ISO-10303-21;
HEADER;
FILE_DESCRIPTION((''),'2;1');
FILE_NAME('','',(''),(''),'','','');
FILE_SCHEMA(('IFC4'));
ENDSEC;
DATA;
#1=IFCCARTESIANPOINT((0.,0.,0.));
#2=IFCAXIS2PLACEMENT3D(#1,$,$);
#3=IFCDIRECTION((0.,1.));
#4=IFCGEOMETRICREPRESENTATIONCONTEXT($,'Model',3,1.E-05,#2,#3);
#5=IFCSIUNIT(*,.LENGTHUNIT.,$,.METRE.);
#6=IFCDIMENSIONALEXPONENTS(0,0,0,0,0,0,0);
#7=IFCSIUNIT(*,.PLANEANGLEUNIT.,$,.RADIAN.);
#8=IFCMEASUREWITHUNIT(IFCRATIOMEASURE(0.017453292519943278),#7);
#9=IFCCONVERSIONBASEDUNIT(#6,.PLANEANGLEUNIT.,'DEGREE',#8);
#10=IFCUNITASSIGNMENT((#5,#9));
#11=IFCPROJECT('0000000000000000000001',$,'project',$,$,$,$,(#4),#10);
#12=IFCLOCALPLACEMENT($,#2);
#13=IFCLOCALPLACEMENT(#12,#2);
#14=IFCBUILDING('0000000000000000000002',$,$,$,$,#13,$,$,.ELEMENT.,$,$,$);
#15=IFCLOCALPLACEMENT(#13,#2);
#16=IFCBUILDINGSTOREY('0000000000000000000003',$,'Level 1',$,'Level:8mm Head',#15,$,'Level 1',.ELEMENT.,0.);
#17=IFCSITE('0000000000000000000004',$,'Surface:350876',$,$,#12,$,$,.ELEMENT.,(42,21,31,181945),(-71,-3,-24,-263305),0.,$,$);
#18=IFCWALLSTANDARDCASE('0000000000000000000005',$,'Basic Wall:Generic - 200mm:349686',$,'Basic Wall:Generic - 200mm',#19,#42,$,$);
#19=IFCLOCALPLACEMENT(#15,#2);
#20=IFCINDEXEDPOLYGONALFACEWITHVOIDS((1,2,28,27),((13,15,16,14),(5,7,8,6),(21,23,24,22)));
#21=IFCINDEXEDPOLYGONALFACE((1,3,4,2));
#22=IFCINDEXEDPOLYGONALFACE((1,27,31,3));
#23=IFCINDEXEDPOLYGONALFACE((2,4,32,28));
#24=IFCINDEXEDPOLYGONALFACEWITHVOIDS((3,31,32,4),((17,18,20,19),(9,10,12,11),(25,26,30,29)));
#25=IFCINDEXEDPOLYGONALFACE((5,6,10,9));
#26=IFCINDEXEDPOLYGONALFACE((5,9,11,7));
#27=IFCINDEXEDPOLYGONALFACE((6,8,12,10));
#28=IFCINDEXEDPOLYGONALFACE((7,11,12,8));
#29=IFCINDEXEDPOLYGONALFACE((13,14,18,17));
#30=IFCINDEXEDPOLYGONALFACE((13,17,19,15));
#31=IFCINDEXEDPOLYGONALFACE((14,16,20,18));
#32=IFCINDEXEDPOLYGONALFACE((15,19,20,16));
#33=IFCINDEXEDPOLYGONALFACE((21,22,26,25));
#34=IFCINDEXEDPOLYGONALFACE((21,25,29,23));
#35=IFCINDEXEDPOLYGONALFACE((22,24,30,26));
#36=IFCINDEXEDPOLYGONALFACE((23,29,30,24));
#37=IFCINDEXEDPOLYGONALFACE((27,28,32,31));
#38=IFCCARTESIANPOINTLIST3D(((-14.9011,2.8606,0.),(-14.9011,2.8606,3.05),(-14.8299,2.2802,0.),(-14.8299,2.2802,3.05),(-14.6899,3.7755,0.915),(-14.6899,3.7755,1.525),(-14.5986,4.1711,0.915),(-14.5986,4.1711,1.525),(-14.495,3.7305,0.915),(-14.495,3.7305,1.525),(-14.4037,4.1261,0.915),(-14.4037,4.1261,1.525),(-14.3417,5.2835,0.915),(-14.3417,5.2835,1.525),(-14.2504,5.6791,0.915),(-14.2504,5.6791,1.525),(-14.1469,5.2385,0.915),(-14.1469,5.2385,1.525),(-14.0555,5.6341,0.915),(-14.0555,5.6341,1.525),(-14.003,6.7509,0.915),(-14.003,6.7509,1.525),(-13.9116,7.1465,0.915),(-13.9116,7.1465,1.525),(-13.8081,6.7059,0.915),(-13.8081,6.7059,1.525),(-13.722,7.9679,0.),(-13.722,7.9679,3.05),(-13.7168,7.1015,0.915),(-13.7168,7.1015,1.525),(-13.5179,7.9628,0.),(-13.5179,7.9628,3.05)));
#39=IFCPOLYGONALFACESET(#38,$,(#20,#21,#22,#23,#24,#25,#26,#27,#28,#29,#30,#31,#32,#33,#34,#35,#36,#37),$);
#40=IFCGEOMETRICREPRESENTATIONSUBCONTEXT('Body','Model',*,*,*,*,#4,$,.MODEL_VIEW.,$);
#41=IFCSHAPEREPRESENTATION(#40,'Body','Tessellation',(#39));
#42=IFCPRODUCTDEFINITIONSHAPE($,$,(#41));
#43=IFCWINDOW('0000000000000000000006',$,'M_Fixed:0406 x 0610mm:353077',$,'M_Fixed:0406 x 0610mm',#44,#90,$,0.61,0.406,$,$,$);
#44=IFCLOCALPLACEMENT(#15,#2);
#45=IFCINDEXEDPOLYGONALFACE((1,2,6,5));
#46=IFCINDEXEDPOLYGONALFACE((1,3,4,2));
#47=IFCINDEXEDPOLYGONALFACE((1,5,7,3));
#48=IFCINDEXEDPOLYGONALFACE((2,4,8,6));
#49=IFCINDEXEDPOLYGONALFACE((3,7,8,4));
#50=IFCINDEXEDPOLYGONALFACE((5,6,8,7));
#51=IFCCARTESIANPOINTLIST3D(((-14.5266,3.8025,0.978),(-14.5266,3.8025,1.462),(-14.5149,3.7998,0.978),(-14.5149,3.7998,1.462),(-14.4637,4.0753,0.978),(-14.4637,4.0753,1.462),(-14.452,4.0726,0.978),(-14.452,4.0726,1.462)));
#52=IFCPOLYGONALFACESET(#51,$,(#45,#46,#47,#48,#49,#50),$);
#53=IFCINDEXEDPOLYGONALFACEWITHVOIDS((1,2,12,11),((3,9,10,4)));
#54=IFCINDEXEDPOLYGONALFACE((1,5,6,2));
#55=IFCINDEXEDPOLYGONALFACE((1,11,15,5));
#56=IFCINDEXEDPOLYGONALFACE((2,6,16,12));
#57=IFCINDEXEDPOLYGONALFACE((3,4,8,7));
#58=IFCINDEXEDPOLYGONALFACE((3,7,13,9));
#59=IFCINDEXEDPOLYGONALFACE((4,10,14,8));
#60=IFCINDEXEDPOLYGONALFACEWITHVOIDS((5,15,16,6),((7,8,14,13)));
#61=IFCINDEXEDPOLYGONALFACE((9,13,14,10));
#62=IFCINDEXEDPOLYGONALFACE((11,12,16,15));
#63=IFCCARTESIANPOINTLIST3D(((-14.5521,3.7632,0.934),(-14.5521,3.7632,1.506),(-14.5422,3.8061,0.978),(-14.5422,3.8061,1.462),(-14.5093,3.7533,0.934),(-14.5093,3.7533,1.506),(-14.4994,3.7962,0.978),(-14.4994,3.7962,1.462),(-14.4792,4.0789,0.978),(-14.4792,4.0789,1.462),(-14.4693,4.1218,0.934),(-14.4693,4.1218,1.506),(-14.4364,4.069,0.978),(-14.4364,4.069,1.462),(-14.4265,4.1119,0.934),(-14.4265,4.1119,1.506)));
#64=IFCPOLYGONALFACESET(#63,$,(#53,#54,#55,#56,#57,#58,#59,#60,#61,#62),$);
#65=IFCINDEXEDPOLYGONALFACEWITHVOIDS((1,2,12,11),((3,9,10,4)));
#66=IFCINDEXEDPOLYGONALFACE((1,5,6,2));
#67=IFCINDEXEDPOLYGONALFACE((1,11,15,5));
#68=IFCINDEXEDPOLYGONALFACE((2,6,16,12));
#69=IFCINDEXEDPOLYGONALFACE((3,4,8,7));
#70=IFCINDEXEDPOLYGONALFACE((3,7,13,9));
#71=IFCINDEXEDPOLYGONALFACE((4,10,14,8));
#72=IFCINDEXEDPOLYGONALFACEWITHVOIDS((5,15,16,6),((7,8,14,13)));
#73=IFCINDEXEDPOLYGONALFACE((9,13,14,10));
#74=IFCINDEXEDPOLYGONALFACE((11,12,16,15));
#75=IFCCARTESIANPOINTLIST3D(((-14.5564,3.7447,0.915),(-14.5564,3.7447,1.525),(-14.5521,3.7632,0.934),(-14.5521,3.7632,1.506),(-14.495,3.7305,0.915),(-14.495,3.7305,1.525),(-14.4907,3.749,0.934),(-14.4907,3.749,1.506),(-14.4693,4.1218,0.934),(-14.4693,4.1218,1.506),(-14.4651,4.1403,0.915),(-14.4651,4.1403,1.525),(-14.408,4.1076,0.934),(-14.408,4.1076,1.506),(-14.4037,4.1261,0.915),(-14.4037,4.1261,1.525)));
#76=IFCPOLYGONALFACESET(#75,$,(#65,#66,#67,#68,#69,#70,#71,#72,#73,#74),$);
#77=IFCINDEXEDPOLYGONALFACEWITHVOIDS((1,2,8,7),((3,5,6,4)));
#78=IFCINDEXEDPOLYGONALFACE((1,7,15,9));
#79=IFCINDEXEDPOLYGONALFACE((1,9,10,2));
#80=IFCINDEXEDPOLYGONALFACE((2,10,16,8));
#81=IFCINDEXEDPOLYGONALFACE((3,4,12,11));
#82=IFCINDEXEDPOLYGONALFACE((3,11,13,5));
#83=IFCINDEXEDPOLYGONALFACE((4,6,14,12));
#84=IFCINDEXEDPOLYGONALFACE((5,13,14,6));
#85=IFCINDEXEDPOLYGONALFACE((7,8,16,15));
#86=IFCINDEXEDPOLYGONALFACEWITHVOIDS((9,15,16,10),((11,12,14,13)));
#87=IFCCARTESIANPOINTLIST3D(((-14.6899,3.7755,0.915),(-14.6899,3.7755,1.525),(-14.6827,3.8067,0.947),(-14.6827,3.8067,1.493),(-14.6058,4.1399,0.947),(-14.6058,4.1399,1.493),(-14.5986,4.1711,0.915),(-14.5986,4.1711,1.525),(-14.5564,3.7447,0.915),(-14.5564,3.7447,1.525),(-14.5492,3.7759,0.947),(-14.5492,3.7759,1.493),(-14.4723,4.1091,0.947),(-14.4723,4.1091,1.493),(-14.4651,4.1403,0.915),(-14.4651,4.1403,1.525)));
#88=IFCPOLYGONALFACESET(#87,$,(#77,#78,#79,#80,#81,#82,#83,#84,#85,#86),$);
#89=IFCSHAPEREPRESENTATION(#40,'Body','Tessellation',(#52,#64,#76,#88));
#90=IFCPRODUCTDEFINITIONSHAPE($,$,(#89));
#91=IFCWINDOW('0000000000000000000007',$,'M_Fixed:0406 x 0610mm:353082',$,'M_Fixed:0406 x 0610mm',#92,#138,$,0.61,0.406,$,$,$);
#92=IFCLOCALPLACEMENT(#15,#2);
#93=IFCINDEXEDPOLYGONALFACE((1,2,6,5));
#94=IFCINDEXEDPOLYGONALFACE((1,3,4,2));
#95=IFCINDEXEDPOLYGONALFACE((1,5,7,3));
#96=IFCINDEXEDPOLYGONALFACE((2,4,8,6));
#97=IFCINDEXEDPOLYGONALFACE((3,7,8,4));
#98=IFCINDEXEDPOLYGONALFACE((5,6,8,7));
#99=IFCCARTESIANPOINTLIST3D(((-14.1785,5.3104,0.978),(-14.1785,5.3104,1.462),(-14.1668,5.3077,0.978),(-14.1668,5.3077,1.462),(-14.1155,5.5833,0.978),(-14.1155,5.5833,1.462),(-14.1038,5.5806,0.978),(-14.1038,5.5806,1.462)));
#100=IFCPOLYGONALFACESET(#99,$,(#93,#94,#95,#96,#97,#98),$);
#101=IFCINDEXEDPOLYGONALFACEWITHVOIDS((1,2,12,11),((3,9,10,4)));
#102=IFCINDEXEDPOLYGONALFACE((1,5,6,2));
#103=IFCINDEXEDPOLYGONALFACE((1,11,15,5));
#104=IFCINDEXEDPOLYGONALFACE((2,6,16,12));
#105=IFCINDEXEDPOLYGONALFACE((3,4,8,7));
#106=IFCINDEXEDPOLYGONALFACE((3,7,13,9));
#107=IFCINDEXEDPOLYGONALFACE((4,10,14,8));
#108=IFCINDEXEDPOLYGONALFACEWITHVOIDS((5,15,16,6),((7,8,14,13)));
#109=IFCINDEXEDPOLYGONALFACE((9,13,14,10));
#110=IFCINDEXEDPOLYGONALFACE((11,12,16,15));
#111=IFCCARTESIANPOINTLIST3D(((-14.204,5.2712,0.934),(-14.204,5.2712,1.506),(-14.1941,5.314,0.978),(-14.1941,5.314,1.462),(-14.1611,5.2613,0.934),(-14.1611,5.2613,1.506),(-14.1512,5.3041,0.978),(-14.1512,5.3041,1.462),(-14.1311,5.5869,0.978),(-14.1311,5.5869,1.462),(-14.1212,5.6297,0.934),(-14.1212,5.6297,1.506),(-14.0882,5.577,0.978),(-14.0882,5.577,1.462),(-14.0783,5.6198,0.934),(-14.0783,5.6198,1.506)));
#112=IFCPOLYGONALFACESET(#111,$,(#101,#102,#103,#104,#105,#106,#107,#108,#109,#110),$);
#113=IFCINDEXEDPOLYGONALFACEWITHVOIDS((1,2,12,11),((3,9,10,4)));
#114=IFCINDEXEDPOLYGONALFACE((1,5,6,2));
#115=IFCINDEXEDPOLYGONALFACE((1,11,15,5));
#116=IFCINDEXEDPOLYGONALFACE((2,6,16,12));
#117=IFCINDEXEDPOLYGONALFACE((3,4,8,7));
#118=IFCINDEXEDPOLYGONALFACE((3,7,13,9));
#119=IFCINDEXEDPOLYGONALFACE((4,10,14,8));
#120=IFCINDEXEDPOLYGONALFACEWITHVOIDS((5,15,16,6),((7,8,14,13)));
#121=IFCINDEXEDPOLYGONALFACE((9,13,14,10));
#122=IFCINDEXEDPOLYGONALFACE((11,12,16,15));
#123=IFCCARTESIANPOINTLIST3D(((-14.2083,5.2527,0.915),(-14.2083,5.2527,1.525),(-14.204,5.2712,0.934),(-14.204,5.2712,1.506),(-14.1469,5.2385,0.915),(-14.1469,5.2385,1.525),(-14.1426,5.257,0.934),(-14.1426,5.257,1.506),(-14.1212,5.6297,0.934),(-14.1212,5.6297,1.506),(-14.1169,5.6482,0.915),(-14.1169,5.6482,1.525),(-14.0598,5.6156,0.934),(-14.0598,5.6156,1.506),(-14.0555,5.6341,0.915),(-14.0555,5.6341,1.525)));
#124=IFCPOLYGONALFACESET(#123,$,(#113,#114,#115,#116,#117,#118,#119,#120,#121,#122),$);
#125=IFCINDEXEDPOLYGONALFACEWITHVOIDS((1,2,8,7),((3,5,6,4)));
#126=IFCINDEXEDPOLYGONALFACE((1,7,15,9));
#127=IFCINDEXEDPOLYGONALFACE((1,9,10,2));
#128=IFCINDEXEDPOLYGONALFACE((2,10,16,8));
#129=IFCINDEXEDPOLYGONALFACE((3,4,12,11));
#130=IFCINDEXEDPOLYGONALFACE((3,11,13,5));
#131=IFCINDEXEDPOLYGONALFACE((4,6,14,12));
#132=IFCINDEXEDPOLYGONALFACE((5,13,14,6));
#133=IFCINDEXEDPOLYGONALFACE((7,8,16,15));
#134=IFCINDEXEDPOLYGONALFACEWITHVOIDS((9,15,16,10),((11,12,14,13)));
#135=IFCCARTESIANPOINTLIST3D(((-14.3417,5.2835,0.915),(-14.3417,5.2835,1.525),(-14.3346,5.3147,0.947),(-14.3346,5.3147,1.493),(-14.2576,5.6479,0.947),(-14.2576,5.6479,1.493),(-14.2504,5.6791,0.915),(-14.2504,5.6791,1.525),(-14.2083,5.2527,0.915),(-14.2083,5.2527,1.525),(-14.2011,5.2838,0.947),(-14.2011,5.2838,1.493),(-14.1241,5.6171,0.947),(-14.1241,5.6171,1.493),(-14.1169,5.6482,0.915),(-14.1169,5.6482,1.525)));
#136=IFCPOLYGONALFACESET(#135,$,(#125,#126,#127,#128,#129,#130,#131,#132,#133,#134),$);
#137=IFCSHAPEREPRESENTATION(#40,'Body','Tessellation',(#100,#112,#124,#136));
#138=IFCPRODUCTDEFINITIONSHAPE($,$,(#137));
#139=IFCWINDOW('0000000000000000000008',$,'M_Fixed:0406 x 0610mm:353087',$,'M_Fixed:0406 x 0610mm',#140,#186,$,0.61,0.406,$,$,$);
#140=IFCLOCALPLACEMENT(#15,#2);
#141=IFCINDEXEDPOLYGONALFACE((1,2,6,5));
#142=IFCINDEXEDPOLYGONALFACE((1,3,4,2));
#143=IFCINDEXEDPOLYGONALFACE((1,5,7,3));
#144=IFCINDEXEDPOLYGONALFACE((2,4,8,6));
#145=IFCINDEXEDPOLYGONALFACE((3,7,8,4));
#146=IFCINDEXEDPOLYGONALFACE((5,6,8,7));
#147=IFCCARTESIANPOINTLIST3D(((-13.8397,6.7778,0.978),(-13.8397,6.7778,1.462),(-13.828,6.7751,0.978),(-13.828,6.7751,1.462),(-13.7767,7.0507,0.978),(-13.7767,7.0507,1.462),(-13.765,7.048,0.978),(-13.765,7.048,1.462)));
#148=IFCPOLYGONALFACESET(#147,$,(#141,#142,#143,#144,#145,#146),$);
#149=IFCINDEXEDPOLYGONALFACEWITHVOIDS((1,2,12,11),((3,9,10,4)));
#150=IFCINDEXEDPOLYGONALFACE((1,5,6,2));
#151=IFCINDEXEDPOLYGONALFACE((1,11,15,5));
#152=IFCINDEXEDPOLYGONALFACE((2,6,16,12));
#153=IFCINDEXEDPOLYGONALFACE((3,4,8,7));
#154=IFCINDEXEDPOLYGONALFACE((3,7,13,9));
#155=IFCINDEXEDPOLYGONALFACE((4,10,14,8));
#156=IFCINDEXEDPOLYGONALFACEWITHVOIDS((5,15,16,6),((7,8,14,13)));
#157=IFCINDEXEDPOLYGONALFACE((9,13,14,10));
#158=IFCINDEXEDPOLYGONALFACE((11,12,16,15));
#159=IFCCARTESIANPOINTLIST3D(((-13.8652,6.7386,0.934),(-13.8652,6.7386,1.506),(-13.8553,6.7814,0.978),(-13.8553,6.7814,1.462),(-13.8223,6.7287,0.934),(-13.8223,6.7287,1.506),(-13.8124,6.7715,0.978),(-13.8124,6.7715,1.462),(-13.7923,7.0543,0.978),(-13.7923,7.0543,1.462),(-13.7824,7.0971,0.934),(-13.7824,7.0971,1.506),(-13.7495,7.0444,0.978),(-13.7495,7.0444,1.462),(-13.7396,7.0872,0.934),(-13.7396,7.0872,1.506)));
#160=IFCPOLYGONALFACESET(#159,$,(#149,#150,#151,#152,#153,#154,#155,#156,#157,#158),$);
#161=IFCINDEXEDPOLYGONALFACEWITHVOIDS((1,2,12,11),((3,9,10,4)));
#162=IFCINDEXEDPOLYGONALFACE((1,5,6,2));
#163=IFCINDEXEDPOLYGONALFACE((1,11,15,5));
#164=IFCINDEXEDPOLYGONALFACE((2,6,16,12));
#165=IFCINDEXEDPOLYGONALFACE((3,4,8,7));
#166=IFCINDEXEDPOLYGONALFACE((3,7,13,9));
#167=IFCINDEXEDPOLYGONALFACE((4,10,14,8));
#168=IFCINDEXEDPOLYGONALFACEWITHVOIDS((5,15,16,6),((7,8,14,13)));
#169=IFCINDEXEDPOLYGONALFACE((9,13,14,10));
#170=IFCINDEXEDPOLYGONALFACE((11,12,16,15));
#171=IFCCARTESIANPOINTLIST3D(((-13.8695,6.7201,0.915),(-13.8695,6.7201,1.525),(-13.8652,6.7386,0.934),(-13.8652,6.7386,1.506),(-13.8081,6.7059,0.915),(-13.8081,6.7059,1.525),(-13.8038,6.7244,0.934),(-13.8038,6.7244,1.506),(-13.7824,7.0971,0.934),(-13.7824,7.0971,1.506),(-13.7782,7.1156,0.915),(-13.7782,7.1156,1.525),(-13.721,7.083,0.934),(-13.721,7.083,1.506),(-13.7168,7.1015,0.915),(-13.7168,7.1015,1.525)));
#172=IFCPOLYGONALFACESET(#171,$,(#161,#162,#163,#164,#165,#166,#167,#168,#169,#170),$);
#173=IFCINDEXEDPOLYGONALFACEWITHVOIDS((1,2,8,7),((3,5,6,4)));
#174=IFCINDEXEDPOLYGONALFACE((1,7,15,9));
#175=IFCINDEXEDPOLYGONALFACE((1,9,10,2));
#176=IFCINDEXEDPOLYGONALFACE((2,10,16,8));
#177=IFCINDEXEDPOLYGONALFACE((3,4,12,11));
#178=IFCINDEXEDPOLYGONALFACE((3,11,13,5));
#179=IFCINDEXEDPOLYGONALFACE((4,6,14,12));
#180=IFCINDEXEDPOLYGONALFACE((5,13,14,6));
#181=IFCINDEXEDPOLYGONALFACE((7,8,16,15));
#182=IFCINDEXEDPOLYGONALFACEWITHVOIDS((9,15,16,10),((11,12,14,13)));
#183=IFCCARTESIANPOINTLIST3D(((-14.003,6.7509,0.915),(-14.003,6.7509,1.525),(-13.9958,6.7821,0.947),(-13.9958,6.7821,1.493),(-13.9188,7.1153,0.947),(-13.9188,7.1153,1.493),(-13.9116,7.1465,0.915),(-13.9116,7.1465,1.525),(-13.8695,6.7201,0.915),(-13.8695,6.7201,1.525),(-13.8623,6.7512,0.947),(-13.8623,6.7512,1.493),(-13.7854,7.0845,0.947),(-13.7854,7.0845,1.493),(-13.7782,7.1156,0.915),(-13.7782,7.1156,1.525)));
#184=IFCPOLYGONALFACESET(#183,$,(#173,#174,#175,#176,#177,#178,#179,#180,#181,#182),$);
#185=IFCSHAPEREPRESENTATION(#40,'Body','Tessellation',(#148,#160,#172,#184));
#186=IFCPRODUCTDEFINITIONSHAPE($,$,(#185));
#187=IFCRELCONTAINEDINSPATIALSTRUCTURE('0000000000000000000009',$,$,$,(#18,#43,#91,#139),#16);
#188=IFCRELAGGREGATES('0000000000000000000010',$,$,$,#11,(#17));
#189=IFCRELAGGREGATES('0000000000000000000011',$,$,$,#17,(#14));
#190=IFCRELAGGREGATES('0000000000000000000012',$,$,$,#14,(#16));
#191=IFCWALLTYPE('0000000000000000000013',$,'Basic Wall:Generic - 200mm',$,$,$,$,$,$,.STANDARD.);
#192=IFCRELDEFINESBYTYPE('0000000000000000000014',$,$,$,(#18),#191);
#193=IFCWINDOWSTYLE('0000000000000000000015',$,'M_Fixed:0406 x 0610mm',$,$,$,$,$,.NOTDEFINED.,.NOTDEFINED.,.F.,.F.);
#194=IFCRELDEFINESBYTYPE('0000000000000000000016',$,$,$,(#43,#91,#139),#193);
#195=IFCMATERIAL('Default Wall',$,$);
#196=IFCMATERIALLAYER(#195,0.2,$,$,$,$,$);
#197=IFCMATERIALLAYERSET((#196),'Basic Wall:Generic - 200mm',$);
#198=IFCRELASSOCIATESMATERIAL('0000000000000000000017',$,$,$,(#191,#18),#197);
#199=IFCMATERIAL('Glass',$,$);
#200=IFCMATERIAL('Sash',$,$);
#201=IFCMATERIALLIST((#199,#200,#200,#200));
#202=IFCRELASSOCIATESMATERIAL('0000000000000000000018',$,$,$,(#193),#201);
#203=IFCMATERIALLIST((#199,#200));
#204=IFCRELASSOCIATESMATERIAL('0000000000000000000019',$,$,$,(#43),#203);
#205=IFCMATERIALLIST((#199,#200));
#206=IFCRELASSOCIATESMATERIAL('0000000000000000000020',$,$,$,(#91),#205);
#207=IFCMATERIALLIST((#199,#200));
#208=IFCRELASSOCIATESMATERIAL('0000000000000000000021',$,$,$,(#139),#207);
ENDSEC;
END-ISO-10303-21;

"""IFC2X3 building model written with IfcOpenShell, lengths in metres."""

from ifc_helpers import new_model, entity, si_unit, converted_unit, direction, frame, frame_2d, origin, place, context, subcontext, project, spatial, polyline, rectangle, outline, extrude, source, transform, mapped, material, material_list, layer, layer_set, layer_usage, type_object, type_shapes, element, fill, save


model = new_model("IFC2X3")

# Units and contexts
model_context = context("Model", 3, precision=1e-05, world=origin(), true_north=direction((0.0, 1.0)))
body_context = subcontext(model_context, "Body", "Model", "MODEL_VIEW")
ifc_project = project(units=[si_unit("LENGTHUNIT", "METRE"), converted_unit("PLANEANGLEUNIT", "DEGREE", entity("IfcRatioMeasure", 0.017453292519943278), si_unit("PLANEANGLEUNIT", "RADIAN"), dimensions=[0, 0, 0, 0, 0, 0, 0])], contexts=[model_context])

# Site, building, storey
site_placement = place(None, origin())
site = spatial("IfcSite", under=ifc_project, at=site_placement, Name="Surface:350876", CompositionType="ELEMENT", RefLatitude=(42, 21, 31, 181945), RefLongitude=(-71, -3, -24, -263305), RefElevation=0.0)
building_placement = place(site_placement, origin())
building = spatial("IfcBuilding", under=site, at=building_placement, CompositionType="ELEMENT")
storey_placement = place(building_placement, origin())
storey = spatial("IfcBuildingStorey", under=building, at=storey_placement, Name="Level 1", ObjectType="Level:8mm Head", LongName="Level 1", CompositionType="ELEMENT", Elevation=0.0)

# Wall, openings, windows
ifc_material_1 = material(Name="Default Wall")
ifc_layer_1 = layer(ifc_material_1, 0.2)
ifc_layer_set_1 = layer_set([ifc_layer_1], Name="Basic Wall:Generic - 200mm")
ifc_layer_usage_1 = layer_usage(ifc_layer_set_1, "AXIS2", "NEGATIVE", 0.1)
wall_type_1 = type_object("IfcWallType", Name="Basic Wall:Generic - 200mm", PredefinedType="STANDARD", material=ifc_layer_set_1)
wall_1_placement = place(storey_placement, frame((-13.6154, 7.9853, 0.0), z_axis=(0.0, 0.0, 1.0), x_axis=(-0.224951, -0.97437, 0.0)))
wall_1 = element("IfcWallStandardCase", 1, at=wall_1_placement, inside=storey, type_object=wall_type_1, material=ifc_layer_usage_1, Name="Basic Wall:Generic - 200mm:349686", ObjectType="Basic Wall:Generic - 200mm", context=body_context, shape_type="SweptSolid", body=[
    extrude(outline(polyline([(5.2826, -0.1), (5.8321, 0.1), (5.2474, 0.1), (0.2042, 0.1), (0.0, 0.1), (0.041, -0.1), (5.2826, -0.1)])), origin(), (0.0, 0.0, 1.0), 3.05),
])
opening_1_placement = place(wall_1_placement, frame((0.884, -0.1, 0.915)))
opening_1 = element("IfcOpeningElement", 2, at=opening_1_placement, cuts=wall_1, ObjectType="Opening", context=body_context, shape_type="SweptSolid", body=[
    extrude(rectangle(XDim=0.61, YDim=0.406, at=frame_2d((0.305, 0.203), x_axis=(1.0, 0.0))), frame((0.0, 0.0, 0.0), z_axis=(0.0, 1.0, 0.0), x_axis=(0.0, 0.0, 1.0)), (0.0, 0.0, 1.0), 0.2),
])
opening_2_placement = place(wall_1_placement, frame((2.39, -0.1, 0.915)))
opening_2 = element("IfcOpeningElement", 3, at=opening_2_placement, cuts=wall_1, ObjectType="Opening", context=body_context, shape_type="SweptSolid", body=[
    extrude(rectangle(XDim=0.61, YDim=0.406, at=frame_2d((0.305, 0.203), x_axis=(1.0, 0.0))), frame((0.0, 0.0, 0.0), z_axis=(0.0, 1.0, 0.0), x_axis=(0.0, 0.0, 1.0)), (0.0, 0.0, 1.0), 0.2),
])
opening_3_placement = place(wall_1_placement, frame((3.9376, -0.1, 0.915)))
opening_3 = element("IfcOpeningElement", 4, at=opening_3_placement, cuts=wall_1, ObjectType="Opening", context=body_context, shape_type="SweptSolid", body=[
    extrude(rectangle(XDim=0.61, YDim=0.406, at=frame_2d((0.305, 0.203), x_axis=(1.0, 0.0))), frame((0.0, 0.0, 0.0), z_axis=(0.0, 1.0, 0.0), x_axis=(0.0, 0.0, 1.0)), (0.0, 0.0, 1.0), 0.2),
])
ifc_material_2 = material(Name="Glass")
ifc_material_3 = material(Name="Sash")
ifc_material_list_1 = material_list([ifc_material_2, ifc_material_3])
ifc_material_list_2 = material_list([ifc_material_2, ifc_material_3, ifc_material_3, ifc_material_3])
window_style = type_object("IfcWindowStyle", Name="M_Fixed:0406 x 0610mm", ConstructionType="NOTDEFINED", OperationType="NOTDEFINED", ParameterTakesPrecedence=False, Sizeable=False, material=ifc_material_list_2)
shared_shape_1 = source(origin(), body_context, "Body", "SweptSolid", [
    extrude(rectangle(XDim=0.012, YDim=0.28, at=frame_2d((0.0, 0.0), x_axis=(1.0, 0.0))), frame((0.203, 0.159, 0.063), z_axis=(0.0, 0.0, 1.0), x_axis=(0.0, -1.0, 0.0)), (0.0, 0.0, 1.0), 0.484),
    extrude(outline(polyline([(-0.184, -0.286), (0.184, -0.286), (0.184, 0.286), (-0.184, 0.286), (-0.184, -0.286)]), holes=[polyline([(-0.14, -0.242), (-0.14, 0.242), (0.14, 0.242), (0.14, -0.242), (-0.14, -0.242)])]), frame((0.203, 0.137, 0.305), z_axis=(0.0, 1.0, 0.0), x_axis=(1.0, 0.0, 0.0)), (0.0, 0.0, 1.0), 0.044),
    extrude(outline(polyline([(-0.203, -0.305), (0.203, -0.305), (0.203, 0.305), (-0.203, 0.305), (-0.203, -0.305)]), holes=[polyline([(-0.184, -0.286), (-0.184, 0.286), (0.184, 0.286), (0.184, -0.286), (-0.184, -0.286)])]), frame((0.203, 0.137, 0.305), z_axis=(0.0, 1.0, 0.0), x_axis=(1.0, 0.0, 0.0)), (0.0, 0.0, 1.0), 0.063),
    extrude(outline(polyline([(-0.203, -0.305), (0.203, -0.305), (0.203, 0.305), (-0.203, 0.305), (-0.203, -0.305)]), holes=[polyline([(-0.171, -0.273), (-0.171, 0.273), (0.171, 0.273), (0.171, -0.273), (-0.171, -0.273)])]), frame((0.203, 0.0, 0.305), z_axis=(0.0, 1.0, 0.0), x_axis=(1.0, 0.0, 0.0)), (0.0, 0.0, 1.0), 0.137),
])
type_shapes(window_style, [shared_shape_1])
window_1_placement = place(opening_3_placement, origin())
window_1 = element("IfcWindow", 5, at=window_1_placement, inside=storey, type_object=window_style, material=ifc_material_list_1, Name="M_Fixed:0406 x 0610mm:353077", ObjectType="M_Fixed:0406 x 0610mm", OverallHeight=0.61, OverallWidth=0.406, context=body_context, shape_type="MappedRepresentation", body=[
    mapped(shared_shape_1, transform((0.0, 0.0, 0.0), scale=1.0)),
])
fill(opening_3, window_1)
ifc_material_list_3 = material_list([ifc_material_2, ifc_material_3])
window_2_placement = place(opening_2_placement, origin())
window_2 = element("IfcWindow", 6, at=window_2_placement, inside=storey, type_object=window_style, material=ifc_material_list_3, Name="M_Fixed:0406 x 0610mm:353082", ObjectType="M_Fixed:0406 x 0610mm", OverallHeight=0.61, OverallWidth=0.406, context=body_context, shape_type="MappedRepresentation", body=[
    mapped(shared_shape_1, transform((0.0, 0.0, 0.0), scale=1.0)),
])
fill(opening_2, window_2)
ifc_material_list_4 = material_list([ifc_material_2, ifc_material_3])
window_3_placement = place(opening_1_placement, origin())
window_3 = element("IfcWindow", 7, at=window_3_placement, inside=storey, type_object=window_style, material=ifc_material_list_4, Name="M_Fixed:0406 x 0610mm:353087", ObjectType="M_Fixed:0406 x 0610mm", OverallHeight=0.61, OverallWidth=0.406, context=body_context, shape_type="MappedRepresentation", body=[
    mapped(shared_shape_1, transform((0.0, 0.0, 0.0), scale=1.0)),
])
fill(opening_1, window_3)

save(model, "model.ifc")
